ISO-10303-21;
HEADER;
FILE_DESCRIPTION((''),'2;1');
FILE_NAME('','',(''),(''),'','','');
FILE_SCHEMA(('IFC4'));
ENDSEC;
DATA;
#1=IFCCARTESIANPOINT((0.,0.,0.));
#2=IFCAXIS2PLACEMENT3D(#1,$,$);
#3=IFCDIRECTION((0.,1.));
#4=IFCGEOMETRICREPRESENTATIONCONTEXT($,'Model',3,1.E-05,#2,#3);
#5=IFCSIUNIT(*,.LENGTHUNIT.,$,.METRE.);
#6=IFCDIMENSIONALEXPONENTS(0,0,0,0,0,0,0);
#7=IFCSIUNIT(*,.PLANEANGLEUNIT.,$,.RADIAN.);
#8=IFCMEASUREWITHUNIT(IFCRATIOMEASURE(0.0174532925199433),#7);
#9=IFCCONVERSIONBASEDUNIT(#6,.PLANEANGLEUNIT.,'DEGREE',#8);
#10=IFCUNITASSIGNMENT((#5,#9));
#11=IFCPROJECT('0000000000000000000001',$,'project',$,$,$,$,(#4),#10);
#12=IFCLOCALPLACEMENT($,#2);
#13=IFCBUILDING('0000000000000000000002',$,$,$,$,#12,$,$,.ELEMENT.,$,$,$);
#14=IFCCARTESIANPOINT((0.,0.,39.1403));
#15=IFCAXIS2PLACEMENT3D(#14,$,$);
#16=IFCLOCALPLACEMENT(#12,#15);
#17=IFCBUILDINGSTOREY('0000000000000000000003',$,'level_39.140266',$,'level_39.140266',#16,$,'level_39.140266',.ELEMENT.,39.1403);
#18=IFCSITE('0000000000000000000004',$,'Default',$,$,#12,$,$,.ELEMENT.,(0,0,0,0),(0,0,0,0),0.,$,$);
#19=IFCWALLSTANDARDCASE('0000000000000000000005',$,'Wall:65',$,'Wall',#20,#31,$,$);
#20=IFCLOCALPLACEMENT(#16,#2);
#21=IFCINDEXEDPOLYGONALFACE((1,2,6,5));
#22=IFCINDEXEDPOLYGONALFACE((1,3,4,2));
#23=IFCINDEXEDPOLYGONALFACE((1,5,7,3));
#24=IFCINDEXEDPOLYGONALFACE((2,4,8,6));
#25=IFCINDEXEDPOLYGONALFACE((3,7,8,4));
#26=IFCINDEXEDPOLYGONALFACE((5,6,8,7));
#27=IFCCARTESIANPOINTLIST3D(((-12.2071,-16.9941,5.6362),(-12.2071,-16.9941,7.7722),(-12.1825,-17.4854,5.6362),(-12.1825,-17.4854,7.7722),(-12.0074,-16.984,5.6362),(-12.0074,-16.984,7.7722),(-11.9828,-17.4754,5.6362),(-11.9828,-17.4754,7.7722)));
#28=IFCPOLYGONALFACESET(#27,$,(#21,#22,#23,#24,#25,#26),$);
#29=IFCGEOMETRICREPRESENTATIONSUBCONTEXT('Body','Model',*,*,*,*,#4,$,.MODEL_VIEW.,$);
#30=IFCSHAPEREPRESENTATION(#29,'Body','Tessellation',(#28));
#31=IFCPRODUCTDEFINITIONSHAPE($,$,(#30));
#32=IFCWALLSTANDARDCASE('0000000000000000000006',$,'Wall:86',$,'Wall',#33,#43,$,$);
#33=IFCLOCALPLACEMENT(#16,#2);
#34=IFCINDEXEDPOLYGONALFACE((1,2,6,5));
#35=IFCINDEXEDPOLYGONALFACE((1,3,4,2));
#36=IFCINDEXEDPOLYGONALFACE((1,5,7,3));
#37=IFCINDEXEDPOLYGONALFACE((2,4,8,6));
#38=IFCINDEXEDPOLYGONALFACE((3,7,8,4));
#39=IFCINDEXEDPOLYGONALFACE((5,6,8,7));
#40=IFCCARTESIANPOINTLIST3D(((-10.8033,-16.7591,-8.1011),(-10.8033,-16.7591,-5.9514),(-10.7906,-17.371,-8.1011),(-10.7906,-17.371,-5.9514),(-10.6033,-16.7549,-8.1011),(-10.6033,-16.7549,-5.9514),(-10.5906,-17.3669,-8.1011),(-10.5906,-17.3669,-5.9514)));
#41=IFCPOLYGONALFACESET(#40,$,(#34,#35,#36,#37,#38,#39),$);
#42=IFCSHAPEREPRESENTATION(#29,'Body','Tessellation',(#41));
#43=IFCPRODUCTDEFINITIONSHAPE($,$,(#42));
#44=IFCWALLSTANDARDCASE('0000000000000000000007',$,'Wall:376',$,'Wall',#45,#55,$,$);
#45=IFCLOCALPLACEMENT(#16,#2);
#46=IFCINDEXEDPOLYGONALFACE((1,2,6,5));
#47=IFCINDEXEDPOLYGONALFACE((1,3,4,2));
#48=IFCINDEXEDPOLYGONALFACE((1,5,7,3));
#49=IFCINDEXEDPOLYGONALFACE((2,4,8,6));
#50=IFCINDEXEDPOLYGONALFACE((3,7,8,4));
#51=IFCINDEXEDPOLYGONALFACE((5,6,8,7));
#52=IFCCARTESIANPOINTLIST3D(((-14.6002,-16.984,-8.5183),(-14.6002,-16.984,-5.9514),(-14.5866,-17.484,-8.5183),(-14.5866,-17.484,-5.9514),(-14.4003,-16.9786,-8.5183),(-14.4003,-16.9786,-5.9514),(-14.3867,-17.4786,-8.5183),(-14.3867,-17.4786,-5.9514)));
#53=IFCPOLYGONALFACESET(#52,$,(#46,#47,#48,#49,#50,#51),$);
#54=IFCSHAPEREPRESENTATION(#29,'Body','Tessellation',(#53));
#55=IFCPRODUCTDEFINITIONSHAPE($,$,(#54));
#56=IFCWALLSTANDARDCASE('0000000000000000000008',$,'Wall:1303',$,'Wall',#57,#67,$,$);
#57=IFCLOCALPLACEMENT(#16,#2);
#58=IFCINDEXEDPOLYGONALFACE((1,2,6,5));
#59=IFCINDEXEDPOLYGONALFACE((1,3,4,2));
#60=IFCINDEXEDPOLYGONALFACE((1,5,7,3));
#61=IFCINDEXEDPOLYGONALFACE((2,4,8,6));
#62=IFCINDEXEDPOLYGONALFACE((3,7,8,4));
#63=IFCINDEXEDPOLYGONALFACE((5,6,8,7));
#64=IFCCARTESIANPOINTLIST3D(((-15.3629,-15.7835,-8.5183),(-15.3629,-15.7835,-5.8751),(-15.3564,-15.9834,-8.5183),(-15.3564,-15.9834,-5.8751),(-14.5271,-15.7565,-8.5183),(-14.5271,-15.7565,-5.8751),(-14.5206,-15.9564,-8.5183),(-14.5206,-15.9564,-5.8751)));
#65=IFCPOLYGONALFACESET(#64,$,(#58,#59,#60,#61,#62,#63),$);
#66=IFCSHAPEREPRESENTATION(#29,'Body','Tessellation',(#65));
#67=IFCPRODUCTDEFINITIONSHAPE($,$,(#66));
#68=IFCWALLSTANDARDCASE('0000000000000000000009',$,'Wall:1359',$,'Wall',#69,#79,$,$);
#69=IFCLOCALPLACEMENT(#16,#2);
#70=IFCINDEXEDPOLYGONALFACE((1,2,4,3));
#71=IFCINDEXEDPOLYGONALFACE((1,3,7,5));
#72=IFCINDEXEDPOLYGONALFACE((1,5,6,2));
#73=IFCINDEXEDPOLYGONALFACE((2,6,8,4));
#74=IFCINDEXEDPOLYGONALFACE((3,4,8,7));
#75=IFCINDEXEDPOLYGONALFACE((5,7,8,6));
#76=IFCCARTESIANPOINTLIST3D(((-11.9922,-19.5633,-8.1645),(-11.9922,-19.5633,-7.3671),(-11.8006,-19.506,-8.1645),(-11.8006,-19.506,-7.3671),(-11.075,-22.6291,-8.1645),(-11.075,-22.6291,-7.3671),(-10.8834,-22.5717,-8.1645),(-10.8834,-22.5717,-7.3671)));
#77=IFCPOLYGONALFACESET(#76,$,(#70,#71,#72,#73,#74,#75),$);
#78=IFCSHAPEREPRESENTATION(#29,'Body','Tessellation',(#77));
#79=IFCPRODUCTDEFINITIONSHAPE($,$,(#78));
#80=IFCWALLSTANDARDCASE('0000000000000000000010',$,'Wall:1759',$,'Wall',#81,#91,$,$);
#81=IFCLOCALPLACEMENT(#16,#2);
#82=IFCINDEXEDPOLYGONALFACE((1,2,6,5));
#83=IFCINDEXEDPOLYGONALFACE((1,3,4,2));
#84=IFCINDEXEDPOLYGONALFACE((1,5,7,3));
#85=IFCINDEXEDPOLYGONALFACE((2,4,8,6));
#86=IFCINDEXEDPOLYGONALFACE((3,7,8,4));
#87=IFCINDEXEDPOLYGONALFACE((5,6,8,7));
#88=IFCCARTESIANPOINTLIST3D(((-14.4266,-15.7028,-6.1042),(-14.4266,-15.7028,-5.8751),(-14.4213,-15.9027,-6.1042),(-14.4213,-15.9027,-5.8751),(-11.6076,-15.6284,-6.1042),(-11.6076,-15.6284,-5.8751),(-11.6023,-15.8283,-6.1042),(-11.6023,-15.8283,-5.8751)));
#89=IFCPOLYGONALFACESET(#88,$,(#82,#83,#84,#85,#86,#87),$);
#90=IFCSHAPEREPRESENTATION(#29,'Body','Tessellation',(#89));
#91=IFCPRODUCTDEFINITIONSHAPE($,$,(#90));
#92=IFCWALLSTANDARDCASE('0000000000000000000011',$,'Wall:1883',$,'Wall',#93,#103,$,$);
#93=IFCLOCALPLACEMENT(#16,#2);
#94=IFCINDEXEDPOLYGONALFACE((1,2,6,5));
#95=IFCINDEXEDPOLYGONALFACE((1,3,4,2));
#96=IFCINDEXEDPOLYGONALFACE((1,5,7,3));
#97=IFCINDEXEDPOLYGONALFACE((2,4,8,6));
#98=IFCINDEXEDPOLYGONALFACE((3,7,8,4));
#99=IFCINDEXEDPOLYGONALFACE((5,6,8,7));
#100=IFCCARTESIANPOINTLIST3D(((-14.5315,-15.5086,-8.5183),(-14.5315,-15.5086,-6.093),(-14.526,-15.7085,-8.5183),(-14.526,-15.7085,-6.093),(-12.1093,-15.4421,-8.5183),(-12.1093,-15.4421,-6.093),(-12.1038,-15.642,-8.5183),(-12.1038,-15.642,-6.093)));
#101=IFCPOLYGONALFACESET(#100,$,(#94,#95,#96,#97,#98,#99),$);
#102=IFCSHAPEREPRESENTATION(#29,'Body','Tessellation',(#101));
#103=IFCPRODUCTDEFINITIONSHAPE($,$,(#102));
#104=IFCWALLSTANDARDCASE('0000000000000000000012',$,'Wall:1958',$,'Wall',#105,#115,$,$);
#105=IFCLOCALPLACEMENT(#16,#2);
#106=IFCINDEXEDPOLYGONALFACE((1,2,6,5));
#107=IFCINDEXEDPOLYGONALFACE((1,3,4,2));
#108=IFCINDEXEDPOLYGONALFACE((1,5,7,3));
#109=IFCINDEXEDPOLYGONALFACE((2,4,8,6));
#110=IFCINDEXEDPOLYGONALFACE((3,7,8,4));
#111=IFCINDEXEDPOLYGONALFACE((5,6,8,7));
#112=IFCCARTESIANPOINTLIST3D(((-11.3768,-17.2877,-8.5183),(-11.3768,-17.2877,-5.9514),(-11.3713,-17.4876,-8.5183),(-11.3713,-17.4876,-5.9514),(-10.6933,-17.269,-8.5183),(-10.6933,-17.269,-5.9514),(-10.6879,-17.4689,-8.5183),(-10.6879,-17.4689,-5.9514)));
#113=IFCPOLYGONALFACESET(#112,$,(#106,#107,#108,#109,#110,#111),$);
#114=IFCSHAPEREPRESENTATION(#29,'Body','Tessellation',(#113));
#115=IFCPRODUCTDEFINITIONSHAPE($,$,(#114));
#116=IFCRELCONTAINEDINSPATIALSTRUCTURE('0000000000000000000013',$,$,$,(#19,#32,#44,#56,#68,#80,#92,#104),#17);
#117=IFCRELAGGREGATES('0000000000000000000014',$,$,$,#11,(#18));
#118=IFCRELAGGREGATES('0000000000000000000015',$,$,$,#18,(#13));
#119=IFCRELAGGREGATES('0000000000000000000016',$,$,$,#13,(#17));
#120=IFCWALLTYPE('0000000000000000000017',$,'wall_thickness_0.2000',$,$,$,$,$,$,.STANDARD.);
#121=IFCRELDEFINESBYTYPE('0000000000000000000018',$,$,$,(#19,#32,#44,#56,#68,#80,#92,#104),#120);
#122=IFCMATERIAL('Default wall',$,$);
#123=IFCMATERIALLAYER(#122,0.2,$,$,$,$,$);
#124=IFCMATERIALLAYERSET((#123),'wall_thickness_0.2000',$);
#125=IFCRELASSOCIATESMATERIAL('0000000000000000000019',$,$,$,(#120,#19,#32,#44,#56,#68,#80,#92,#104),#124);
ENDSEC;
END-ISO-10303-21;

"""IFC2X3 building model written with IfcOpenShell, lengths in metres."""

from ifc_helpers import new_model, entity, si_unit, converted_unit, direction, frame, origin, place, context, subcontext, project, spatial, polyline, outline, extrude, material, layer, layer_set, layer_usage, type_object, element, save


model = new_model("IFC2X3")

# Units and contexts
model_context = context("Model", 3, precision=1e-05, world=origin(), true_north=direction((0.0, 1.0)))
body_context = subcontext(model_context, "Body", "Model", "MODEL_VIEW")
ifc_project = project(units=[si_unit("LENGTHUNIT", "METRE"), converted_unit("PLANEANGLEUNIT", "DEGREE", entity("IfcRatioMeasure", 0.0174532925199433), si_unit("PLANEANGLEUNIT", "RADIAN"), dimensions=[0, 0, 0, 0, 0, 0, 0])], contexts=[model_context])

# Site, building, storey
placement_1 = place(None, origin())
site = spatial("IfcSite", under=ifc_project, at=placement_1, Name="Default", CompositionType="ELEMENT", RefLatitude=(0, 0, 0, 0), RefLongitude=(0, 0, 0, 0), RefElevation=0.0)
building = spatial("IfcBuilding", under=site, at=placement_1, CompositionType="ELEMENT")
storey_placement = place(placement_1, frame((0.0, 0.0, 39.1403)))
storey = spatial("IfcBuildingStorey", under=building, at=storey_placement, Name="level_39.140266", ObjectType="level_39.140266", LongName="level_39.140266", CompositionType="ELEMENT", Elevation=39.1403)

# Walls
ifc_material = material(Name="Default wall")
ifc_layer = layer(ifc_material, 0.2)
ifc_layer_set = layer_set([ifc_layer], Name="wall_thickness_0.2000")
ifc_layer_usage = layer_usage(ifc_layer_set, "AXIS2", "POSITIVE", -0.1)
wall_type = type_object("IfcWallType", Name="wall_thickness_0.2000", PredefinedType="STANDARD", material=ifc_layer_set)
placement_2 = place(placement_1, frame((0.0, 0.0, 44.7765)))
wall_1_placement = place(placement_2, frame((-12.0826, -17.4804, 0.0), z_axis=(0.0, 0.0, 1.0), x_axis=(-0.050071, 0.998746, 0.0)))
element("IfcWallStandardCase", 1, at=wall_1_placement, inside=storey, type_object=wall_type, material=ifc_layer_usage, Name="Wall:65", ObjectType="Wall", context=body_context, shape_type="SweptSolid", body=[
    extrude(outline(polyline([(0.4919, -0.1), (0.4919, 0.1), (0.0, 0.1), (0.0, -0.1), (0.4919, -0.1)])), origin(), (0.0, 0.0, 1.0), 2.136),
])
placement_3 = place(placement_1, frame((0.0, 0.0, 31.0392)))
wall_2_placement = place(placement_3, frame((-10.7033, -16.757, 0.0), z_axis=(0.0, 0.0, 1.0), x_axis=(0.020713, -0.999785, 0.0)))
element("IfcWallStandardCase", 2, at=wall_2_placement, inside=storey, type_object=wall_type, material=ifc_layer_usage, Name="Wall:86", ObjectType="Wall", context=body_context, shape_type="SweptSolid", body=[
    extrude(outline(polyline([(0.6121, -0.1), (0.6121, 0.1), (0.0, 0.1), (0.0, -0.1), (0.6121, -0.1)])), origin(), (0.0, 0.0, 1.0), 2.1497),
])
placement_4 = place(placement_1, frame((0.0, 0.0, 30.622)))
wall_3_placement = place(placement_4, frame((-14.4866, -17.4813, 0.0), z_axis=(0.0, 0.0, 1.0), x_axis=(-0.027325, 0.999627, 0.0)))
element("IfcWallStandardCase", 3, at=wall_3_placement, inside=storey, type_object=wall_type, material=ifc_layer_usage, Name="Wall:376", ObjectType="Wall", context=body_context, shape_type="SweptSolid", body=[
    extrude(outline(polyline([(0.5002, -0.1), (0.5002, 0.1), (0.0, 0.1), (0.0, -0.1), (0.5002, -0.1)])), origin(), (0.0, 0.0, 1.0), 2.5669),
])
placement_5 = place(placement_1, frame((0.0, 0.0, 30.622)))
wall_4_placement = place(placement_5, frame((-14.5238, -15.8565, 0.0), z_axis=(0.0, 0.0, 1.0), x_axis=(-0.99948, -0.032249, 0.0)))
element("IfcWallStandardCase", 4, at=wall_4_placement, inside=storey, type_object=wall_type, material=ifc_layer_usage, Name="Wall:1303", ObjectType="Wall", context=body_context, shape_type="SweptSolid", body=[
    extrude(outline(polyline([(0.8363, -0.1), (0.8363, 0.1), (0.0, 0.1), (0.0, -0.1), (0.8363, -0.1)])), origin(), (0.0, 0.0, 1.0), 2.6432),
])
placement_6 = place(placement_1, frame((0.0, 0.0, 30.9758)))
wall_5_placement = place(placement_6, frame((-11.8964, -19.5346, 0.0), z_axis=(0.0, 0.0, 1.0), x_axis=(0.286605, -0.958049, 0.0)))
element("IfcWallStandardCase", 5, at=wall_5_placement, inside=storey, type_object=wall_type, material=ifc_layer_usage, Name="Wall:1359", ObjectType="Wall", context=body_context, shape_type="SweptSolid", body=[
    extrude(outline(polyline([(3.2, -0.1), (3.2, 0.1), (0.0, 0.1), (0.0, -0.1), (3.2, -0.1)])), origin(), (0.0, 0.0, 1.0), 0.7975),
])
placement_7 = place(placement_1, frame((0.0, 0.0, 33.0361)))
wall_6_placement = place(placement_7, frame((-14.424, -15.8027, 0.0), z_axis=(0.0, 0.0, 1.0), x_axis=(0.999652, 0.026361, 0.0)))
element("IfcWallStandardCase", 6, at=wall_6_placement, inside=storey, type_object=wall_type, material=ifc_layer_usage, Name="Wall:1759", ObjectType="Wall", context=body_context, shape_type="SweptSolid", body=[
    extrude(outline(polyline([(2.82, -0.1), (2.82, 0.1), (0.0, 0.1), (0.0, -0.1), (2.82, -0.1)])), origin(), (0.0, 0.0, 1.0), 0.2291),
])
placement_8 = place(placement_1, frame((0.0, 0.0, 30.622)))
wall_7_placement = place(placement_8, frame((-12.1065, -15.542, 0.0), z_axis=(0.0, 0.0, 1.0), x_axis=(-0.999623, -0.027442, 0.0)))
element("IfcWallStandardCase", 7, at=wall_7_placement, inside=storey, type_object=wall_type, material=ifc_layer_usage, Name="Wall:1883", ObjectType="Wall", context=body_context, shape_type="SweptSolid", body=[
    extrude(outline(polyline([(2.4232, -0.1), (2.4232, 0.1), (0.0, 0.1), (0.0, -0.1), (2.4232, -0.1)])), origin(), (0.0, 0.0, 1.0), 2.4253),
])
placement_9 = place(placement_1, frame((0.0, 0.0, 30.622)))
wall_8_placement = place(placement_9, frame((-11.3741, -17.3876, 0.0), z_axis=(0.0, 0.0, 1.0), x_axis=(0.999626, 0.027331, 0.0)))
element("IfcWallStandardCase", 8, at=wall_8_placement, inside=storey, type_object=wall_type, material=ifc_layer_usage, Name="Wall:1958", ObjectType="Wall", context=body_context, shape_type="SweptSolid", body=[
    extrude(outline(polyline([(0.6837, -0.1), (0.6837, 0.1), (0.0, 0.1), (0.0, -0.1), (0.6837, -0.1)])), origin(), (0.0, 0.0, 1.0), 2.5669),
])

save(model, "model.ifc")
